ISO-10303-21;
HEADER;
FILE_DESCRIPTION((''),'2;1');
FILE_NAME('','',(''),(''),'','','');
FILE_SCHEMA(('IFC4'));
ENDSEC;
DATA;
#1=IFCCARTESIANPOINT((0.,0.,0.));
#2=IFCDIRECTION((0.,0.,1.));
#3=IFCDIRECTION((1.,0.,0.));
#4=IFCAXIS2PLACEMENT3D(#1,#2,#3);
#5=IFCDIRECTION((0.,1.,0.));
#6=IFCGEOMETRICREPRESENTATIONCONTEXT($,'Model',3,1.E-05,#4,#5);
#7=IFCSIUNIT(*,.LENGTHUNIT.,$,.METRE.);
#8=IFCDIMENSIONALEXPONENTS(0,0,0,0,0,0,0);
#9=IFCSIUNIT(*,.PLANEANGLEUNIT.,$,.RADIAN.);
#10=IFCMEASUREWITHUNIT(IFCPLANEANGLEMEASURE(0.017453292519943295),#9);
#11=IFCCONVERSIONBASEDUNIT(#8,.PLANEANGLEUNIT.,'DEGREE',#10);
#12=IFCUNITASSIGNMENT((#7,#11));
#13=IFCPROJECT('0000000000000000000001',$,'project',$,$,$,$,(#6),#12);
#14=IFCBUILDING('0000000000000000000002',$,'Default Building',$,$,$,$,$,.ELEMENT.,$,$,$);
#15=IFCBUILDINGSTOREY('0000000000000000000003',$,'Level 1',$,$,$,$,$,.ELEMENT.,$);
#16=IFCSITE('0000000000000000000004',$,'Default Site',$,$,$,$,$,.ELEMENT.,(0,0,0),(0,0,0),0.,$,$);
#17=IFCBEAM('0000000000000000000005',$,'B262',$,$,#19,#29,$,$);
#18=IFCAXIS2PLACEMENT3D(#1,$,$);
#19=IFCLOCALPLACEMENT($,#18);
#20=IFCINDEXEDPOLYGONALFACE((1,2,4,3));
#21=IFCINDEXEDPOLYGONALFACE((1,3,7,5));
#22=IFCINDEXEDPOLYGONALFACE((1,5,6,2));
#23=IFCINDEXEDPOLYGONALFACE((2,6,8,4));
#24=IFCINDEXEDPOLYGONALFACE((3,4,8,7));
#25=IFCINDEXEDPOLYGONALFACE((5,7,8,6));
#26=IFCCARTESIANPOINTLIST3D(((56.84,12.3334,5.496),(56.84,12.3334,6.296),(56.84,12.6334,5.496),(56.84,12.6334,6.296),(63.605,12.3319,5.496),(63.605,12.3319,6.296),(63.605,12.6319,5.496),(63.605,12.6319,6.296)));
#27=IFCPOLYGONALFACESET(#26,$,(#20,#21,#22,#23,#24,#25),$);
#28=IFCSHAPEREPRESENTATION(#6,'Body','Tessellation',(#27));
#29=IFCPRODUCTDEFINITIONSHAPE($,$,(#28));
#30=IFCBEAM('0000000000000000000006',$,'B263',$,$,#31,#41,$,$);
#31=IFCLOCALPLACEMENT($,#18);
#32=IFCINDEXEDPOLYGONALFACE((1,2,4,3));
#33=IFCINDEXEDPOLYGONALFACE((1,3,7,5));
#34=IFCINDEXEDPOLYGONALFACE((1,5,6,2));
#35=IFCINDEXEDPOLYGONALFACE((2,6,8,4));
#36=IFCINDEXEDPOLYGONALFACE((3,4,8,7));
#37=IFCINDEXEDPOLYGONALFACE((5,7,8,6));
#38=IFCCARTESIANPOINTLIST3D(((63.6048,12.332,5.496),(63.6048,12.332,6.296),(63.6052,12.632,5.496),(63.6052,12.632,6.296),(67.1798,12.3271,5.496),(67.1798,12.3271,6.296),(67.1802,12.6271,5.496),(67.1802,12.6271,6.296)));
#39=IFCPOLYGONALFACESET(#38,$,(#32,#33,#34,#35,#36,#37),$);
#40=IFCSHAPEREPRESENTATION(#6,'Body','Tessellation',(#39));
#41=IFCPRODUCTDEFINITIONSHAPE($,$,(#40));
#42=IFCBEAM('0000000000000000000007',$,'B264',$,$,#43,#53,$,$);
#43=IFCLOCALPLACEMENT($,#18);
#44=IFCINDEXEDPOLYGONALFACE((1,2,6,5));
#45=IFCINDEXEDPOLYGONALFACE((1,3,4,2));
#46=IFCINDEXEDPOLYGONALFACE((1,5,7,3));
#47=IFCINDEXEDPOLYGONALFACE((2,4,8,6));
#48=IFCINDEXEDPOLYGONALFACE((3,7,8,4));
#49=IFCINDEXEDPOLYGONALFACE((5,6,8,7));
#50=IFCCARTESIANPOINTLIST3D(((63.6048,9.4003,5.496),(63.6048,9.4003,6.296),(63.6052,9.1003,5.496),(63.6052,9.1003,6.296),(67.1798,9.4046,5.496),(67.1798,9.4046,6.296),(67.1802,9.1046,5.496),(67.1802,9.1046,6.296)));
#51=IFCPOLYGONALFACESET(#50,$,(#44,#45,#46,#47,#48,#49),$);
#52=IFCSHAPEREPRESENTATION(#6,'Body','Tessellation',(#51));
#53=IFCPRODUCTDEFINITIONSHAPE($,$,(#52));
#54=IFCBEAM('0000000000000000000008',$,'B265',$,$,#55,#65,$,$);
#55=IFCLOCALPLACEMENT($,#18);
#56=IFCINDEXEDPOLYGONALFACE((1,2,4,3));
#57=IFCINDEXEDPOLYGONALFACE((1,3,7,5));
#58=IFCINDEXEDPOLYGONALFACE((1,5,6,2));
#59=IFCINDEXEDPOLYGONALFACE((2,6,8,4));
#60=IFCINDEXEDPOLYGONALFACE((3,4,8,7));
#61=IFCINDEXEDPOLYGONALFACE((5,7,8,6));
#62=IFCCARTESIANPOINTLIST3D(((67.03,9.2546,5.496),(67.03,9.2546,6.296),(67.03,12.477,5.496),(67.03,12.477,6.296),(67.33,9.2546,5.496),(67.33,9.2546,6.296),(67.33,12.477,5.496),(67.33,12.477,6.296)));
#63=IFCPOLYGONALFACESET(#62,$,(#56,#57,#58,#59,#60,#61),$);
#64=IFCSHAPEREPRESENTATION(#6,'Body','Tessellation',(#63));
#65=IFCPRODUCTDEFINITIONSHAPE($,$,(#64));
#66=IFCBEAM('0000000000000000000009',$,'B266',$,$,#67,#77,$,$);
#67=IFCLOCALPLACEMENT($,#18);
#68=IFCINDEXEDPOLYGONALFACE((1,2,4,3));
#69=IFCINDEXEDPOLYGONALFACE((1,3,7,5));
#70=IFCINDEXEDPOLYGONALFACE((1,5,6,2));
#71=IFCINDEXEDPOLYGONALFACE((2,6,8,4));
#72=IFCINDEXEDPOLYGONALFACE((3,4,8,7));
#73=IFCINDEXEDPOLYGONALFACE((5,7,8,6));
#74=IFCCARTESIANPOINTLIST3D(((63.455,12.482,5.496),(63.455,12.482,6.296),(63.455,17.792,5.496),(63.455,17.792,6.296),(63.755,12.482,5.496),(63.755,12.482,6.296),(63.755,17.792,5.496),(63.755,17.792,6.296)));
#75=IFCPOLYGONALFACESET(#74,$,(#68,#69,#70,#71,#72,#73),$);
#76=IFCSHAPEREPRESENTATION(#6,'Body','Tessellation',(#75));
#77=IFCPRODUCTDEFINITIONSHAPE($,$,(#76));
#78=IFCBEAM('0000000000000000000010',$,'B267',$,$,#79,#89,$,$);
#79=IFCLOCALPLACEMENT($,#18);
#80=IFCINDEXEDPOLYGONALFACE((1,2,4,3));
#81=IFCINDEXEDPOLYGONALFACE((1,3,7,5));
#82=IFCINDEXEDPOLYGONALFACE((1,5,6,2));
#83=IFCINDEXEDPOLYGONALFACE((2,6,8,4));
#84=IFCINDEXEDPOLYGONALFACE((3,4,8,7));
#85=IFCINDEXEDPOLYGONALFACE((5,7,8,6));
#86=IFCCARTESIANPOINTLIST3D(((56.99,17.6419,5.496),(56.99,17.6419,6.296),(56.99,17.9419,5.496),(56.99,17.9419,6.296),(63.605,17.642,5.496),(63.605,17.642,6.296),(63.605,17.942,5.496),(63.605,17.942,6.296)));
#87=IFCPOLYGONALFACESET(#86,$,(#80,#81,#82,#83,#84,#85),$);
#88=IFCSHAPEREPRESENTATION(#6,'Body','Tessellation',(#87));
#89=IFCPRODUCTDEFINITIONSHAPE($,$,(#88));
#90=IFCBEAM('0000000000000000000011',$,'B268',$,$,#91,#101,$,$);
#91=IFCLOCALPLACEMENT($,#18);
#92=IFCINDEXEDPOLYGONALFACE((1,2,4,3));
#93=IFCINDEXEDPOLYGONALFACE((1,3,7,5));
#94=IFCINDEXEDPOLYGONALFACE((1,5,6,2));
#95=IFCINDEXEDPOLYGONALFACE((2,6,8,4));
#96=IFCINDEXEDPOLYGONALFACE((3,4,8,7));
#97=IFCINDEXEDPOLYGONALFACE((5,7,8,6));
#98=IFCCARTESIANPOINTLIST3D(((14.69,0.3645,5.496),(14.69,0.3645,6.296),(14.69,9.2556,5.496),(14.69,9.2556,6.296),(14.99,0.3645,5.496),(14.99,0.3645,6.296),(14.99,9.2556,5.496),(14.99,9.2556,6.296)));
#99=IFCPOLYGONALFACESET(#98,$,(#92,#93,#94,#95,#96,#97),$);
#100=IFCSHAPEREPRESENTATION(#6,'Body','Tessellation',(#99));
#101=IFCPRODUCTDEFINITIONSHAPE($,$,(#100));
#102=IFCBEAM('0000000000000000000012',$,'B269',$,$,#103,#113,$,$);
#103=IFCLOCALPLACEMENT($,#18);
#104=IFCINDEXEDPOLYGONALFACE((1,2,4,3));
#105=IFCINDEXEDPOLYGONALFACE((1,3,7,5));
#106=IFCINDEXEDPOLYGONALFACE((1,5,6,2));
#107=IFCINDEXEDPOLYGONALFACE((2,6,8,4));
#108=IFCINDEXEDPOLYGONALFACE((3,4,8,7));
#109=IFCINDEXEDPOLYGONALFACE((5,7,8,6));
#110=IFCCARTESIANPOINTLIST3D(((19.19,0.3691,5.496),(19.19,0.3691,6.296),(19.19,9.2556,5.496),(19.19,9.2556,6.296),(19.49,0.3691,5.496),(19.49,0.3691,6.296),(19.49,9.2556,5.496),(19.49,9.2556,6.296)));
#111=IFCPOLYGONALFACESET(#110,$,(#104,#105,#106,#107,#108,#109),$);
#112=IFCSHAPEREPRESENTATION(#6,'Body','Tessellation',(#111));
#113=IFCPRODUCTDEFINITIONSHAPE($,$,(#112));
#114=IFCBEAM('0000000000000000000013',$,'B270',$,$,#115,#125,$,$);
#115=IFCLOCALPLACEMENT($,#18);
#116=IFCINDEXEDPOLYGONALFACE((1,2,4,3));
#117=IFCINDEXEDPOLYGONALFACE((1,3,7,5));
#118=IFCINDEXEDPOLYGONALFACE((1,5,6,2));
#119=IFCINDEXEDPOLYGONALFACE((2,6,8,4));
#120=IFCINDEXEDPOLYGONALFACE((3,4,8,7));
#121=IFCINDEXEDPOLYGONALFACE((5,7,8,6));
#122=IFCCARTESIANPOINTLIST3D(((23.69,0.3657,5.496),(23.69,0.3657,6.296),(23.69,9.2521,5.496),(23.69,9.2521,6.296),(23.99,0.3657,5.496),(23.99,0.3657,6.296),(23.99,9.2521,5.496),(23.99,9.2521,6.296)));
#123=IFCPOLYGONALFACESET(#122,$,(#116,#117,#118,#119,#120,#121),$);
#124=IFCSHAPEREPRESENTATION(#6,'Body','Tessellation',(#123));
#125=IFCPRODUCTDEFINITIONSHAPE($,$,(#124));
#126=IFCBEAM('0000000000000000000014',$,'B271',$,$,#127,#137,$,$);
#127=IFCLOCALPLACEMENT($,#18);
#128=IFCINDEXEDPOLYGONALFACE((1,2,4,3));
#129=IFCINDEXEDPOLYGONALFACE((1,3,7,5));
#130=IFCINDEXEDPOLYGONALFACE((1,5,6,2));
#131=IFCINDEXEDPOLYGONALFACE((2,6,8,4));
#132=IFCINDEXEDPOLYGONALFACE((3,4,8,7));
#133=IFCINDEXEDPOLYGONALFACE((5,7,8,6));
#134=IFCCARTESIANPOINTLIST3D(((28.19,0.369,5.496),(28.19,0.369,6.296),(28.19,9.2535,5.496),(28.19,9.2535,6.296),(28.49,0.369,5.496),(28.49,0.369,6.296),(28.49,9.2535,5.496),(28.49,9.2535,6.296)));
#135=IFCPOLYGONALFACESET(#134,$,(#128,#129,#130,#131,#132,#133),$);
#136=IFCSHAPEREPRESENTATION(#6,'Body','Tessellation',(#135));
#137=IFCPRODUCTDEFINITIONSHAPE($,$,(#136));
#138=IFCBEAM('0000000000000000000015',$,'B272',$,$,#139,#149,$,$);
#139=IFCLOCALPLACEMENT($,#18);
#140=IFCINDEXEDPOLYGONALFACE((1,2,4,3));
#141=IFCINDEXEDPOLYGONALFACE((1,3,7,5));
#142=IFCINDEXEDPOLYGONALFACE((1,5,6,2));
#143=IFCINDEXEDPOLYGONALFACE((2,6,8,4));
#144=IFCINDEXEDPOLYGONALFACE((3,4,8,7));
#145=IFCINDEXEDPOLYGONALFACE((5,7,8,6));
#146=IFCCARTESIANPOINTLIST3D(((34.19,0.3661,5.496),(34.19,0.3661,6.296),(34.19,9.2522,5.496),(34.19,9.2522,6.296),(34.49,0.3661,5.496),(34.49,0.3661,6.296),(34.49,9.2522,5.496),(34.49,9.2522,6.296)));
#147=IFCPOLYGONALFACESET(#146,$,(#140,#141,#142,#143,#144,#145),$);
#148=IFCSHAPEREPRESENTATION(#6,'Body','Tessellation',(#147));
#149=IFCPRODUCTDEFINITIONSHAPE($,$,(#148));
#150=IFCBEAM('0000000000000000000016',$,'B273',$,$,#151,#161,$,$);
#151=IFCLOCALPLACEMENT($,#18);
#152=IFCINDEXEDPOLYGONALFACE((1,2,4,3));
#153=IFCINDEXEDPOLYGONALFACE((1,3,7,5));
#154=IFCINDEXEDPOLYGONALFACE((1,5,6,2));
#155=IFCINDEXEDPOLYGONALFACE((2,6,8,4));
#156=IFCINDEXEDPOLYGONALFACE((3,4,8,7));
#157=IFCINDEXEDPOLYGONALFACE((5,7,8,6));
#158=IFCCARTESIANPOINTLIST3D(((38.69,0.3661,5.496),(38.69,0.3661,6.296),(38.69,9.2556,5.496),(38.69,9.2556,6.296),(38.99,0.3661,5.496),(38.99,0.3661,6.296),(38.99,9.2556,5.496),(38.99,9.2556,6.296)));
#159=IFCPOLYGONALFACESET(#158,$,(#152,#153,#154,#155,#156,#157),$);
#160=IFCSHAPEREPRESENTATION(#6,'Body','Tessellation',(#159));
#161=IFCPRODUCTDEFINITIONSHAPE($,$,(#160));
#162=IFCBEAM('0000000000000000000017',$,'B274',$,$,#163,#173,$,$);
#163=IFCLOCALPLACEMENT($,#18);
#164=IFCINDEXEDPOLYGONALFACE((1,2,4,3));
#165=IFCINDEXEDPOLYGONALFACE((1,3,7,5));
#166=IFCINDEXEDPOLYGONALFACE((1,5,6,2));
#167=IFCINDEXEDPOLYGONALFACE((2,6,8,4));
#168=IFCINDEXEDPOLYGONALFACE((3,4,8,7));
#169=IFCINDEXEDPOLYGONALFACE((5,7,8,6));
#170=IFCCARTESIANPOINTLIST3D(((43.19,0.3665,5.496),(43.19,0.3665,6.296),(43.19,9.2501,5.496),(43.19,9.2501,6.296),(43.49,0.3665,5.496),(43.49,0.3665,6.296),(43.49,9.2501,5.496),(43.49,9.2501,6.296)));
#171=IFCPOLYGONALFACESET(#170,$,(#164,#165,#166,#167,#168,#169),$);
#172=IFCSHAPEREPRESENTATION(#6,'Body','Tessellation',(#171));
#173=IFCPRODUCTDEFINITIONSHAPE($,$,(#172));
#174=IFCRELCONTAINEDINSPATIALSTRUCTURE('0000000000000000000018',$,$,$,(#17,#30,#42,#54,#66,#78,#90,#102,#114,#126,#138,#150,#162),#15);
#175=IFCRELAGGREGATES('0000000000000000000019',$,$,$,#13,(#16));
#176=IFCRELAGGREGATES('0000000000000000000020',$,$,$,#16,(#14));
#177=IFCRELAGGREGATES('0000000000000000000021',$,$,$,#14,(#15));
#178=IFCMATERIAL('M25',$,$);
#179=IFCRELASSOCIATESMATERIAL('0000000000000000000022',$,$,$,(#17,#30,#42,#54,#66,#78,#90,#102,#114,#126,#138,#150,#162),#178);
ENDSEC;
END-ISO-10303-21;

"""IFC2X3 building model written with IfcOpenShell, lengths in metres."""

from ifc_helpers import new_model, entity, si_unit, converted_unit, direction, frame, frame_2d, origin_with_axes, place, context, project, spatial, rectangle, extrude, material, element, save


model = new_model("IFC2X3")

# Units and contexts
model_context = context("Model", 3, precision=1e-05, world=origin_with_axes(), true_north=direction((0.0, 1.0, 0.0)))
ifc_project = project(units=[si_unit("LENGTHUNIT", "METRE"), converted_unit("PLANEANGLEUNIT", "DEGREE", entity("IfcPlaneAngleMeasure", 0.017453292519943295), si_unit("PLANEANGLEUNIT", "RADIAN"), dimensions=[0, 0, 0, 0, 0, 0, 0])], contexts=[model_context])

# Site, building, storey
site = spatial("IfcSite", under=ifc_project, Name="Default Site", CompositionType="ELEMENT", RefLatitude=(0, 0, 0), RefLongitude=(0, 0, 0), RefElevation=0.0)
building = spatial("IfcBuilding", under=site, Name="Default Building", CompositionType="ELEMENT")
storey = spatial("IfcBuildingStorey", under=building, Name="Level 1", CompositionType="ELEMENT")

# Beams
ifc_material = material(Name="M25")
placement = place(None, origin_with_axes())
element("IfcBeam", 1, at=placement, inside=storey, material=ifc_material, Name="B262", context=model_context, shape_type="SweptSolid", body=[
    extrude(rectangle(XDim=0.3, YDim=0.8, at=frame_2d((0.0, 0.0), x_axis=(0.0, 1.0, 0.0))), frame((56.84, 12.4834, 5.896), z_axis=(1.0, -0.000216, 0.0), x_axis=(0.0, 0.0, -1.0)), (0.0, 0.0, 1.0), 6.765),
])
element("IfcBeam", 2, at=placement, inside=storey, material=ifc_material, Name="B263", context=model_context, shape_type="SweptSolid", body=[
    extrude(rectangle(XDim=0.3, YDim=0.8, at=frame_2d((0.0, 0.0), x_axis=(0.0, 1.0, 0.0))), frame((63.605, 12.482, 5.896), z_axis=(0.999999, -0.001379, 0.0), x_axis=(0.0, 0.0, -1.0)), (0.0, 0.0, 1.0), 3.575),
])
element("IfcBeam", 3, at=placement, inside=storey, material=ifc_material, Name="B264", context=model_context, shape_type="SweptSolid", body=[
    extrude(rectangle(XDim=0.3, YDim=0.8, at=frame_2d((0.0, 0.0), x_axis=(0.0, 1.0, 0.0))), frame((63.605, 9.2503, 5.896), z_axis=(0.999999, 0.001188, 0.0), x_axis=(0.0, 0.0, -1.0)), (0.0, 0.0, 1.0), 3.575),
])
element("IfcBeam", 4, at=placement, inside=storey, material=ifc_material, Name="B265", context=model_context, shape_type="SweptSolid", body=[
    extrude(rectangle(XDim=0.3, YDim=0.8, at=frame_2d((0.0, 0.0), x_axis=(0.0, 1.0, 0.0))), frame((67.18, 9.2546, 5.896), z_axis=(0.0, 1.0, 0.0), x_axis=(0.0, 0.0, -1.0)), (0.0, 0.0, 1.0), 3.2224),
])
element("IfcBeam", 5, at=placement, inside=storey, material=ifc_material, Name="B266", context=model_context, shape_type="SweptSolid", body=[
    extrude(rectangle(XDim=0.3, YDim=0.8, at=frame_2d((0.0, 0.0), x_axis=(0.0, 1.0, 0.0))), frame((63.605, 12.482, 5.896), z_axis=(0.0, 1.0, 0.0), x_axis=(0.0, 0.0, -1.0)), (0.0, 0.0, 1.0), 5.3101),
])
element("IfcBeam", 6, at=placement, inside=storey, material=ifc_material, Name="B267", context=model_context, shape_type="SweptSolid", body=[
    extrude(rectangle(XDim=0.3, YDim=0.8, at=frame_2d((0.0, 0.0), x_axis=(0.0, 1.0, 0.0))), frame((56.99, 17.7919, 5.896), z_axis=(1.0, 0.00002, 0.0), x_axis=(0.0, 0.0, -1.0)), (0.0, 0.0, 1.0), 6.615),
])
element("IfcBeam", 7, at=placement, inside=storey, material=ifc_material, Name="B268", context=model_context, shape_type="SweptSolid", body=[
    extrude(rectangle(XDim=0.3, YDim=0.8, at=frame_2d((0.0, 0.0), x_axis=(0.0, 1.0, 0.0))), frame((14.84, 0.3645, 5.896), z_axis=(0.0, 1.0, 0.0), x_axis=(0.0, 0.0, -1.0)), (0.0, 0.0, 1.0), 8.891),
])
element("IfcBeam", 8, at=placement, inside=storey, material=ifc_material, Name="B269", context=model_context, shape_type="SweptSolid", body=[
    extrude(rectangle(XDim=0.3, YDim=0.8, at=frame_2d((0.0, 0.0), x_axis=(0.0, 1.0, 0.0))), frame((19.34, 0.3691, 5.896), z_axis=(0.0, 1.0, 0.0), x_axis=(0.0, 0.0, -1.0)), (0.0, 0.0, 1.0), 8.8865),
])
element("IfcBeam", 9, at=placement, inside=storey, material=ifc_material, Name="B270", context=model_context, shape_type="SweptSolid", body=[
    extrude(rectangle(XDim=0.3, YDim=0.8, at=frame_2d((0.0, 0.0), x_axis=(0.0, 1.0, 0.0))), frame((23.84, 0.3657, 5.896), z_axis=(0.0, 1.0, 0.0), x_axis=(0.0, 0.0, -1.0)), (0.0, 0.0, 1.0), 8.8864),
])
element("IfcBeam", 10, at=placement, inside=storey, material=ifc_material, Name="B271", context=model_context, shape_type="SweptSolid", body=[
    extrude(rectangle(XDim=0.3, YDim=0.8, at=frame_2d((0.0, 0.0), x_axis=(0.0, 1.0, 0.0))), frame((28.34, 0.369, 5.896), z_axis=(0.0, 1.0, 0.0), x_axis=(0.0, 0.0, -1.0)), (0.0, 0.0, 1.0), 8.8845),
])
element("IfcBeam", 11, at=placement, inside=storey, material=ifc_material, Name="B272", context=model_context, shape_type="SweptSolid", body=[
    extrude(rectangle(XDim=0.3, YDim=0.8, at=frame_2d((0.0, 0.0), x_axis=(0.0, 1.0, 0.0))), frame((34.34, 0.3661, 5.896), z_axis=(0.0, 1.0, 0.0), x_axis=(0.0, 0.0, -1.0)), (0.0, 0.0, 1.0), 8.8861),
])
element("IfcBeam", 12, at=placement, inside=storey, material=ifc_material, Name="B273", context=model_context, shape_type="SweptSolid", body=[
    extrude(rectangle(XDim=0.3, YDim=0.8, at=frame_2d((0.0, 0.0), x_axis=(0.0, 1.0, 0.0))), frame((38.84, 0.3661, 5.896), z_axis=(0.0, 1.0, 0.0), x_axis=(0.0, 0.0, -1.0)), (0.0, 0.0, 1.0), 8.8895),
])
element("IfcBeam", 13, at=placement, inside=storey, material=ifc_material, Name="B274", context=model_context, shape_type="SweptSolid", body=[
    extrude(rectangle(XDim=0.3, YDim=0.8, at=frame_2d((0.0, 0.0), x_axis=(0.0, 1.0, 0.0))), frame((43.34, 0.3665, 5.896), z_axis=(0.0, 1.0, 0.0), x_axis=(0.0, 0.0, -1.0)), (0.0, 0.0, 1.0), 8.8836),
])

save(model, "model.ifc")
